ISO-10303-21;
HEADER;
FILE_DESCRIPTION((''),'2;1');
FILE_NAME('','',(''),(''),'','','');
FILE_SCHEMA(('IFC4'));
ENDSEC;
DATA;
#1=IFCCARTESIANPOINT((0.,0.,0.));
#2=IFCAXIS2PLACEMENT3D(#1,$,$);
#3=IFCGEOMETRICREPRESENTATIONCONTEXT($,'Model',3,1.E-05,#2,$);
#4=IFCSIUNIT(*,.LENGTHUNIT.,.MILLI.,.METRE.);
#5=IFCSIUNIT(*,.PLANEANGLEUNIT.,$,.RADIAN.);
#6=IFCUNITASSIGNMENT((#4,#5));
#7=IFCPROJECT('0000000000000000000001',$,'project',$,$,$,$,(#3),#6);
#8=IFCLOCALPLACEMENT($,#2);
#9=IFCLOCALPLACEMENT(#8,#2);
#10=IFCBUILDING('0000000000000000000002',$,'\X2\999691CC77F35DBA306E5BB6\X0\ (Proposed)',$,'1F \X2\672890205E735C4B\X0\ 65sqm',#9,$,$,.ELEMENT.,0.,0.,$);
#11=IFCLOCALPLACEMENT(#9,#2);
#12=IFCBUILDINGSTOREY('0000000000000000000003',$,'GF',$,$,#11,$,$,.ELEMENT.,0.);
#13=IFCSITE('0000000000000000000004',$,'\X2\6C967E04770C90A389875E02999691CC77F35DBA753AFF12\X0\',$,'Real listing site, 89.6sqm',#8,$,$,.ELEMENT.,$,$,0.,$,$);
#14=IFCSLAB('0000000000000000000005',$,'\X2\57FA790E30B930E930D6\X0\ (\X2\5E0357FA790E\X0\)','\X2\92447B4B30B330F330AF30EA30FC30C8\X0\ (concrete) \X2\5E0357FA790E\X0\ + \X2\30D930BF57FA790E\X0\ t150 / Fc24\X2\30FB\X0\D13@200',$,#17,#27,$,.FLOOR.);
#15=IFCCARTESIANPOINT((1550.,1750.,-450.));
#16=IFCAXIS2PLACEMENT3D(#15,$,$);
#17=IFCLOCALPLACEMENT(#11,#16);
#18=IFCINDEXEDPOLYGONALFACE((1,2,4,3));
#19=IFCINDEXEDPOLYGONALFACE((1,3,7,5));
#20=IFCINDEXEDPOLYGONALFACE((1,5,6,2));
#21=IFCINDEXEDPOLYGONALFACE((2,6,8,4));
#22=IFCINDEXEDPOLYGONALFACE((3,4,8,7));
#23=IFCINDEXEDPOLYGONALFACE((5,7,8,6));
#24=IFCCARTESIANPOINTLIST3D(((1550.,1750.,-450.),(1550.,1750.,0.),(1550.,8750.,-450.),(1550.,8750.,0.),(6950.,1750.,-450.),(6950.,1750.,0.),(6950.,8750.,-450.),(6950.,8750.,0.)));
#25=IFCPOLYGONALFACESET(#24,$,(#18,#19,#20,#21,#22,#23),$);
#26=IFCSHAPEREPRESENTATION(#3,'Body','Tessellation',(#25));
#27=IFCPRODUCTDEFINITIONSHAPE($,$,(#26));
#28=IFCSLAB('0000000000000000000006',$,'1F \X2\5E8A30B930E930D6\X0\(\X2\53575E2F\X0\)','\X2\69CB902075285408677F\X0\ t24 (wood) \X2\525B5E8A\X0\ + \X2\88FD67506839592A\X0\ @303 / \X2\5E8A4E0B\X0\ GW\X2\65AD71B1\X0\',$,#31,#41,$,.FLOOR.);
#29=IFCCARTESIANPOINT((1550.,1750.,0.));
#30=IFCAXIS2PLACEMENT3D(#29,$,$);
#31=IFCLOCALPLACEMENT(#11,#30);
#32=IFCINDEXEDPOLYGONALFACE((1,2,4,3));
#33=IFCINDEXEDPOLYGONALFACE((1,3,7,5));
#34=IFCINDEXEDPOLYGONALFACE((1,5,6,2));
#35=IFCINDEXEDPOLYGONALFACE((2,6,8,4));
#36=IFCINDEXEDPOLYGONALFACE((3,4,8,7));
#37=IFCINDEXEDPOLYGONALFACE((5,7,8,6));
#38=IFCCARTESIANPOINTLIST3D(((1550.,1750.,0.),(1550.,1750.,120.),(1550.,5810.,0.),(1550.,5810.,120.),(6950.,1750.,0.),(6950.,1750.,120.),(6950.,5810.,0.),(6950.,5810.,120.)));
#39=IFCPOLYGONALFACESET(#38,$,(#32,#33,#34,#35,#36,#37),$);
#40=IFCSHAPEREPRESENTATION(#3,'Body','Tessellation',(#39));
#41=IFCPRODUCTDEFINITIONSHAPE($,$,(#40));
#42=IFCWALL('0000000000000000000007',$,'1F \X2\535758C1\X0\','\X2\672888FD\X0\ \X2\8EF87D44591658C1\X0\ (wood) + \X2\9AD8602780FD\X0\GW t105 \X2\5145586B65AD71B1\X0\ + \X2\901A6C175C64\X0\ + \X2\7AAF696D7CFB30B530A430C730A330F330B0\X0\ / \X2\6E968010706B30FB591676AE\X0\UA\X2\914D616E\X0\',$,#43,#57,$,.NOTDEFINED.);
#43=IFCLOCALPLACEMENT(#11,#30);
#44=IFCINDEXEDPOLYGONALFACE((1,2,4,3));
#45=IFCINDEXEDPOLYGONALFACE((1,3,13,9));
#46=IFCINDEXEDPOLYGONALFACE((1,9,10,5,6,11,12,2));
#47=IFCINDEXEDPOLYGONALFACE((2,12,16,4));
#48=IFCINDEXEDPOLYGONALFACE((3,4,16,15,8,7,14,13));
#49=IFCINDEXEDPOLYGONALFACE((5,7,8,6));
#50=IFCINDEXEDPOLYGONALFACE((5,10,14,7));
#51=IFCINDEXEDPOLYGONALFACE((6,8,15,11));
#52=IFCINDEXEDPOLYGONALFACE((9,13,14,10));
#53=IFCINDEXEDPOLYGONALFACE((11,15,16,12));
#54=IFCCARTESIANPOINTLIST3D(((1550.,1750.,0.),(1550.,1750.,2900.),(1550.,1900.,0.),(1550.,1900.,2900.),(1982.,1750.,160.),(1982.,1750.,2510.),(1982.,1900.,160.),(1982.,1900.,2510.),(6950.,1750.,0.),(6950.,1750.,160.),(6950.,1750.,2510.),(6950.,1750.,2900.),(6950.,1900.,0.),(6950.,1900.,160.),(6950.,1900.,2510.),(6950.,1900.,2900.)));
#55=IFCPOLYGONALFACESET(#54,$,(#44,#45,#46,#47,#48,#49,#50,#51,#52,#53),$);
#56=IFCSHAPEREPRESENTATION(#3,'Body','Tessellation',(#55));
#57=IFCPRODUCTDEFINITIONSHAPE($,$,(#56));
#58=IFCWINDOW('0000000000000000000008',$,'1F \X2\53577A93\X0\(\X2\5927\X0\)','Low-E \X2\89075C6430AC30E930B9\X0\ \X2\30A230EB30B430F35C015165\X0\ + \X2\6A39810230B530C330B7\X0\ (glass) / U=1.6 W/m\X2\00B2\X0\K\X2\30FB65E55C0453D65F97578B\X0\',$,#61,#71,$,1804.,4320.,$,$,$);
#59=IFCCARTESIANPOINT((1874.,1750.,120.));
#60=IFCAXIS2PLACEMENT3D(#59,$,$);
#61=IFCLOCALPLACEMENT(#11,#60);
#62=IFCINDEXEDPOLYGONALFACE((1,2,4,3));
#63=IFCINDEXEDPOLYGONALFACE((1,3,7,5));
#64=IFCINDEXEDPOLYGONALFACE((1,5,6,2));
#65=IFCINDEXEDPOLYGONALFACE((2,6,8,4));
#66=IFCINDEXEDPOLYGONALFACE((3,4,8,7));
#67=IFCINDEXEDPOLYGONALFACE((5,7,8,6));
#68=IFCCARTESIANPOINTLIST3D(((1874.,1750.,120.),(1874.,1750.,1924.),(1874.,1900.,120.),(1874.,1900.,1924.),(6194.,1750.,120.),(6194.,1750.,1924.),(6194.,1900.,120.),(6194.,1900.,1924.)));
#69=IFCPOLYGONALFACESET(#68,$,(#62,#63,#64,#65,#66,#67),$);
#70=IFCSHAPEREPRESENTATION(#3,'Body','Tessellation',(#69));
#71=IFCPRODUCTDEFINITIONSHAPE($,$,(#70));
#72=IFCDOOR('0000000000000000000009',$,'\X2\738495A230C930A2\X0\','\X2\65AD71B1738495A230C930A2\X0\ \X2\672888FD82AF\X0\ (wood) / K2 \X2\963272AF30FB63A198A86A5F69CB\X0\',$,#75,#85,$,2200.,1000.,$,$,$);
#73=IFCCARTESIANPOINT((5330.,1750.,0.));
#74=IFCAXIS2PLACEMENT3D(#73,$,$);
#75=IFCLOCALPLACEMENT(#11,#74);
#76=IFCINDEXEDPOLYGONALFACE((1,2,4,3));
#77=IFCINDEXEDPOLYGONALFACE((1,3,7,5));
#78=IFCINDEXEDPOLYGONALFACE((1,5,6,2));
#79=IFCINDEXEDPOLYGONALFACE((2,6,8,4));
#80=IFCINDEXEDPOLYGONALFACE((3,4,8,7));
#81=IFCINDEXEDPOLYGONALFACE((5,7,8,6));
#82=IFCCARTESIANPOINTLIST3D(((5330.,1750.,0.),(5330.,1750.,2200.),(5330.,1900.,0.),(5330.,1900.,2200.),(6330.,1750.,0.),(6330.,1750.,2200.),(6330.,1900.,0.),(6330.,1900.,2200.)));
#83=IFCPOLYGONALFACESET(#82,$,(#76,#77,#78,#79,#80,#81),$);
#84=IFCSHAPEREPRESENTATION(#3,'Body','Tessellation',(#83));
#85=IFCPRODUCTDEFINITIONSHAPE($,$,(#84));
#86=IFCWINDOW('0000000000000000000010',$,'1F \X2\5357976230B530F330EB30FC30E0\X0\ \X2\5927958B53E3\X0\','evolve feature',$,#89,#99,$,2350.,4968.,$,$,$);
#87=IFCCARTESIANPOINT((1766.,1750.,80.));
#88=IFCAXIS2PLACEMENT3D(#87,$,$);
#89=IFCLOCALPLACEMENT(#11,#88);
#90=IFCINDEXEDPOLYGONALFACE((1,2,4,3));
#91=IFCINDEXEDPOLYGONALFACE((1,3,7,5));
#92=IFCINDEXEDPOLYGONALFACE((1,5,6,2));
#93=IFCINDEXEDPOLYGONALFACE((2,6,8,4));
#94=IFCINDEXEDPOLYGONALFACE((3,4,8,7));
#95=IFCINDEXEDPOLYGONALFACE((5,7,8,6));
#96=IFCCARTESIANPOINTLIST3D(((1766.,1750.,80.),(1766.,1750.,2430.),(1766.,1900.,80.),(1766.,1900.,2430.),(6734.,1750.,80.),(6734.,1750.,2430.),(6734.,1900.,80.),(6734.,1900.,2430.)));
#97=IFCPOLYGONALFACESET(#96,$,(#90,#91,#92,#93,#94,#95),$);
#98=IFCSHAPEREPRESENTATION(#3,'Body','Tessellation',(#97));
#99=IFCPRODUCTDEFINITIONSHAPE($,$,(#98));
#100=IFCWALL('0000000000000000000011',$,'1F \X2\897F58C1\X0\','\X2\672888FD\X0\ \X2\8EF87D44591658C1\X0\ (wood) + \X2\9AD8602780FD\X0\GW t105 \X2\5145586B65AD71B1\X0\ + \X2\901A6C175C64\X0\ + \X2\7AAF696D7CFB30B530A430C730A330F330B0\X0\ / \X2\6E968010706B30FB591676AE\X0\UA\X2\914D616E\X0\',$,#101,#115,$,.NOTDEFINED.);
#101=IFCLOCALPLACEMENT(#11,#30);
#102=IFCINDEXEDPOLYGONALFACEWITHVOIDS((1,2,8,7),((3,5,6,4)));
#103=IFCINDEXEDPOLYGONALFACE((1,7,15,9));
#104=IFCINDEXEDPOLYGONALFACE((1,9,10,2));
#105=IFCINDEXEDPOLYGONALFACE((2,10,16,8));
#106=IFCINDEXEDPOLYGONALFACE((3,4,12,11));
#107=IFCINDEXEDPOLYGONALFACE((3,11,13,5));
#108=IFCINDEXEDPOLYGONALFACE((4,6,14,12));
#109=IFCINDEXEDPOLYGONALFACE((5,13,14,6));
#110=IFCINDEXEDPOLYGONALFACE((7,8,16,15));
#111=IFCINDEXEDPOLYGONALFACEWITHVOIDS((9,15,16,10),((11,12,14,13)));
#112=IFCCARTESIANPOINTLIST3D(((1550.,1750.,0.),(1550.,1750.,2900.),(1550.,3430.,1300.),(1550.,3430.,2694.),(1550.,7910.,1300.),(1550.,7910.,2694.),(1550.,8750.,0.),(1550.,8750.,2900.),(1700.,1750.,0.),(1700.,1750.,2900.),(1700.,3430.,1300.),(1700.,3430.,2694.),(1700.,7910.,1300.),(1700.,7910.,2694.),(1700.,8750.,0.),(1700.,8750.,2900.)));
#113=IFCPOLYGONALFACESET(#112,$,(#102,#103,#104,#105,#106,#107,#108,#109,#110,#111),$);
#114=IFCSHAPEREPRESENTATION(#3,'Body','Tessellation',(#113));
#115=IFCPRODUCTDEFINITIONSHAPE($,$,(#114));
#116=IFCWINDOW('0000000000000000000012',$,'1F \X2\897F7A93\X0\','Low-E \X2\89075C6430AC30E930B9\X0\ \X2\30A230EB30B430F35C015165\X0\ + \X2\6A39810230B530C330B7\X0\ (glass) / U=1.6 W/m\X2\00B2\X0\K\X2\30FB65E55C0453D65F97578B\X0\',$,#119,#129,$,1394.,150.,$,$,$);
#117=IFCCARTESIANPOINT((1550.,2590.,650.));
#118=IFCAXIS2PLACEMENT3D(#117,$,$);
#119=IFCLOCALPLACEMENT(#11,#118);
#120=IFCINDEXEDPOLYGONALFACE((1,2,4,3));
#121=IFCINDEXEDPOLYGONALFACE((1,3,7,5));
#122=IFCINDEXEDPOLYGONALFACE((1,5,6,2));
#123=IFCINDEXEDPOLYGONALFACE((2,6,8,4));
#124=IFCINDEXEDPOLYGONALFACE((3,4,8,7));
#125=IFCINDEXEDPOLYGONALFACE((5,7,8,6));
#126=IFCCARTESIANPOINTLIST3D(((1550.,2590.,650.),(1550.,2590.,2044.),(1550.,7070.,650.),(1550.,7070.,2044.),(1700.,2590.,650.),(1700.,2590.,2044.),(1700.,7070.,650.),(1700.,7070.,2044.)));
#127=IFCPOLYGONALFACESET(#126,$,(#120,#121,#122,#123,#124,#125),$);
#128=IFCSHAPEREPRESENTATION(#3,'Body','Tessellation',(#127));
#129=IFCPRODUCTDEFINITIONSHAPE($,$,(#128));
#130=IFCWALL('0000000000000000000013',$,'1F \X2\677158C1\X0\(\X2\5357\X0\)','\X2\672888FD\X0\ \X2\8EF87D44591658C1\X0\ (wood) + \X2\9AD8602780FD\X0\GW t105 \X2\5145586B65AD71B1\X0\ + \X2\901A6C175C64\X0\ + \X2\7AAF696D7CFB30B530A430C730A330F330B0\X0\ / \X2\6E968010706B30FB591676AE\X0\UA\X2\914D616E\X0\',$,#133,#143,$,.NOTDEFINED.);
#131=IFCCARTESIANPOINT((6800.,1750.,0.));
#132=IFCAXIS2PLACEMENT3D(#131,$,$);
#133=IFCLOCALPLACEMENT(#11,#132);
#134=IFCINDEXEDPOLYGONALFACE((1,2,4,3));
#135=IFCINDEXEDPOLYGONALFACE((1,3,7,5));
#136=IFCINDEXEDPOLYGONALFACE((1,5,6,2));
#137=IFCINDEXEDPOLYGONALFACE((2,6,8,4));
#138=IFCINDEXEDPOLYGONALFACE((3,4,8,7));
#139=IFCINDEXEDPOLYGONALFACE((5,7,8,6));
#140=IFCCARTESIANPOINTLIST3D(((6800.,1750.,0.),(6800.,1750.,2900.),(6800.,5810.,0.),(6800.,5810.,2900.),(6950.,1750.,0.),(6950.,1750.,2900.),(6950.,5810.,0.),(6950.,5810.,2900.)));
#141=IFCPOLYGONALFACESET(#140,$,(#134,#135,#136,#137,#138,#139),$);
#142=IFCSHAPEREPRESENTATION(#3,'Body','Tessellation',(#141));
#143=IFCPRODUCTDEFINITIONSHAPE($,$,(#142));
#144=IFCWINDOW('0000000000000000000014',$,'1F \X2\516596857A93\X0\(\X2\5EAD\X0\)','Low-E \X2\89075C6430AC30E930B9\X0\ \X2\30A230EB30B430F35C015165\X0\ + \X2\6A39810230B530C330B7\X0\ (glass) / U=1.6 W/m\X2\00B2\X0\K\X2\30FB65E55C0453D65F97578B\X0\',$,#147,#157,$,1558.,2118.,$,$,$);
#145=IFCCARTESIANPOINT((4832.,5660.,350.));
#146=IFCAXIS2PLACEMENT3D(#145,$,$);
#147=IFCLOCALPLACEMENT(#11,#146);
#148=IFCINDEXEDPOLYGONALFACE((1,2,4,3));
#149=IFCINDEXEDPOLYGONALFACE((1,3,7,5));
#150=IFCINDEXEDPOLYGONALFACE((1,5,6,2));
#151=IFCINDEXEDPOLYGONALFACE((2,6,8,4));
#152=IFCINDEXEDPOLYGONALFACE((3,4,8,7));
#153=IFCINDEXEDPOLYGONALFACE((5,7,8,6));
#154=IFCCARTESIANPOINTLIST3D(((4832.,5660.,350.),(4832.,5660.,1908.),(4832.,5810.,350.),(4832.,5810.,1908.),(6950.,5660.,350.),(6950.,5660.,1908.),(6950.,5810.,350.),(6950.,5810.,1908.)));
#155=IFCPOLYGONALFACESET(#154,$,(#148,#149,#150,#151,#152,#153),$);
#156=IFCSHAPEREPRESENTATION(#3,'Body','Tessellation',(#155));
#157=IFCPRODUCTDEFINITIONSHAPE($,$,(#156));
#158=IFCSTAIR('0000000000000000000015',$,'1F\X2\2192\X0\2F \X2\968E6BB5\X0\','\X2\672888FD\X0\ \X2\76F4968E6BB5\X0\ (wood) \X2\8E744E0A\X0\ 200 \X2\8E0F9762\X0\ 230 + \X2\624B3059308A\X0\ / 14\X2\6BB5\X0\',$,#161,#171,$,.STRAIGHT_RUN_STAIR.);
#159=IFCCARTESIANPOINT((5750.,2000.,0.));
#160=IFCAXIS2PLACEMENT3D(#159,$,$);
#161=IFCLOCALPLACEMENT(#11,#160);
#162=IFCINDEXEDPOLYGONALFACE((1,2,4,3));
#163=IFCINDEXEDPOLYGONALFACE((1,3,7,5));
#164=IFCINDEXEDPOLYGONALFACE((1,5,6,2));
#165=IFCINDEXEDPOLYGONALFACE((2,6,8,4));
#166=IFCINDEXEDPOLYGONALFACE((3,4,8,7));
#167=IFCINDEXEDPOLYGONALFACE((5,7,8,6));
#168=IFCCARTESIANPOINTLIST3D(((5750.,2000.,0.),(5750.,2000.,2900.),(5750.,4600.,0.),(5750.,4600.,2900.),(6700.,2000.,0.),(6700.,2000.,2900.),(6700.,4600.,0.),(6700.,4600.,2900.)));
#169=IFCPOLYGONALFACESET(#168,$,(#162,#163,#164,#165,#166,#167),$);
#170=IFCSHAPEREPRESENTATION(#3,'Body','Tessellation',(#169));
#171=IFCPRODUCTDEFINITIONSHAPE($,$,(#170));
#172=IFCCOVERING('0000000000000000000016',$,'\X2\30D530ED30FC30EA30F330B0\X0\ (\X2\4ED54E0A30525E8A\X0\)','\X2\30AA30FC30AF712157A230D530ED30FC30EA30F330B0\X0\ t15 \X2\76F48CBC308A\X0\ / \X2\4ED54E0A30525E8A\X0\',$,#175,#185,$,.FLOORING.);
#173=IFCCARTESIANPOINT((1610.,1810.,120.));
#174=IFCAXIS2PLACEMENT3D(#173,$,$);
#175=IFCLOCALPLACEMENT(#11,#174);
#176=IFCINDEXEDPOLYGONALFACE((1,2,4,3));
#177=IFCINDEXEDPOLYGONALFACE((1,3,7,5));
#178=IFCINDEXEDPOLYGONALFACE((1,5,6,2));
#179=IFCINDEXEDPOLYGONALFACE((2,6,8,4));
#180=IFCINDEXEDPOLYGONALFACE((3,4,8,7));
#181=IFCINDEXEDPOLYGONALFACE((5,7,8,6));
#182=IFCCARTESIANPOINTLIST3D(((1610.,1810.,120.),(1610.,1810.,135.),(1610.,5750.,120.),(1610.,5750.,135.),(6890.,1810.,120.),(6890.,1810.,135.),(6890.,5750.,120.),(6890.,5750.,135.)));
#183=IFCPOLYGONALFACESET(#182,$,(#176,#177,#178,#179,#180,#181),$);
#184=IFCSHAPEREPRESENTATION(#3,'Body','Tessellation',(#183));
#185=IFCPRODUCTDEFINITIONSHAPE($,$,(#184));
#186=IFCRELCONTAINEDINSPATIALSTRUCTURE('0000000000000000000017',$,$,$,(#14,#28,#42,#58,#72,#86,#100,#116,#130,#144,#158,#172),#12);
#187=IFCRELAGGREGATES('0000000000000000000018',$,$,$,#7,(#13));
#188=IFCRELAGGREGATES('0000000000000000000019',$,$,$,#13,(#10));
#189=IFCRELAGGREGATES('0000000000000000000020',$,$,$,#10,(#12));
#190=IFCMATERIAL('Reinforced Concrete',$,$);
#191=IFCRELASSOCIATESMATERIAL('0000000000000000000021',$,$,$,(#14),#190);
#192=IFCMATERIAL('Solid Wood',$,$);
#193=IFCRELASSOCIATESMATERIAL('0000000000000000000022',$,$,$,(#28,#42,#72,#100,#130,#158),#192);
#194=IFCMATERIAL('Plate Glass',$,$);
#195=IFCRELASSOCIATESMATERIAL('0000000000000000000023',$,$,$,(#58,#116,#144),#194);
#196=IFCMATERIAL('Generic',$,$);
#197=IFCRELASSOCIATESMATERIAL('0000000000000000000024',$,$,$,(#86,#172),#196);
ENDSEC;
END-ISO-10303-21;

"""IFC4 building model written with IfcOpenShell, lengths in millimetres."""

from ifc_helpers import new_model, si_unit, frame, frame_2d, origin, place, context, project, spatial, rectangle, extrude, material, element, fill, save


model = new_model("IFC4")

# Units and contexts
model_context = context("Model", 3, precision=1e-05, world=origin())
ifc_project = project(units=[si_unit("LENGTHUNIT", "METRE", prefix="MILLI"), si_unit("PLANEANGLEUNIT", "RADIAN")], contexts=[model_context])

# Site, building, storey
site_placement = place(None, origin())
site = spatial("IfcSite", under=ifc_project, at=site_placement, Name="沖縄県那覇市首里石嶺町２", ObjectType="Real listing site, 89.6sqm", CompositionType="ELEMENT", RefElevation=0.0)
building_placement = place(site_placement, origin())
building = spatial("IfcBuilding", under=site, at=building_placement, Name="首里石嶺の家 (Proposed)", ObjectType="1F 木造平屋 65sqm", CompositionType="ELEMENT", ElevationOfRefHeight=0.0, ElevationOfTerrain=0.0)
storey_placement = place(building_placement, origin())
storey = spatial("IfcBuildingStorey", under=building, at=storey_placement, Name="GF", CompositionType="ELEMENT", Elevation=0.0)

# Slabs
ifc_material_1 = material(Name="Reinforced Concrete")
slab_1_placement = place(storey_placement, frame((1550.0, 1750.0, -450.0)))
element("IfcSlab", 1, at=slab_1_placement, inside=storey, material=ifc_material_1, Name="基礎スラブ (布基礎)", Description="鉄筋コンクリート (concrete) 布基礎 + ベタ基礎 t150 / Fc24・D13@200", PredefinedType="FLOOR", context=model_context, shape_type="SweptSolid", body=[
    extrude(rectangle(XDim=5400.0, YDim=7000.0, at=frame_2d((2700.0, 3500.0))), frame((1550.0, 1750.0, -450.0)), (0.0, 0.0, 1.0), 450.0),
])
ifc_material_2 = material(Name="Solid Wood")
slab_2_placement = place(storey_placement, frame((1550.0, 1750.0, 0.0)))
element("IfcSlab", 2, at=slab_2_placement, inside=storey, material=ifc_material_2, Name="1F 床スラブ(南帯)", Description="構造用合板 t24 (wood) 剛床 + 製材根太 @303 / 床下 GW断熱", PredefinedType="FLOOR", context=model_context, shape_type="SweptSolid", body=[
    extrude(rectangle(XDim=5400.0, YDim=4060.0, at=frame_2d((2700.0, 2030.0))), frame((1550.0, 1750.0, 0.0)), (0.0, 0.0, 1.0), 120.0),
])

# Wall, openings, windows, door
wall_1_placement = place(storey_placement, frame((1550.0, 1750.0, 0.0)))
wall_1 = element("IfcWall", 3, at=wall_1_placement, inside=storey, material=ifc_material_2, Name="1F 南壁", Description="木製 軸組外壁 (wood) + 高性能GW t105 充填断熱 + 通気層 + 窯業系サイディング / 準耐火・外皮UA配慮", PredefinedType="NOTDEFINED", context=model_context, shape_type="SweptSolid", body=[
    extrude(rectangle(XDim=5400.0, YDim=150.0, at=frame_2d((2700.0, 75.0))), frame((1550.0, 1750.0, 0.0)), (0.0, 0.0, 1.0), 2900.0),
])
opening_1_placement = place(storey_placement, frame((1874.0, 1750.0, 120.0)))
opening_1 = element("IfcOpeningElement", 4, at=opening_1_placement, cuts=wall_1, PredefinedType="NOTDEFINED", context=model_context, shape_type="SweptSolid", body=[
    extrude(rectangle(XDim=4320.0, YDim=150.0, at=frame_2d((2160.0, 75.0))), frame((1874.0, 1750.0, 120.0)), (0.0, 0.0, 1.0), 1804.0),
])
opening_2_placement = place(storey_placement, frame((5330.0, 1750.0, 0.0)))
opening_2 = element("IfcOpeningElement", 5, at=opening_2_placement, cuts=wall_1, PredefinedType="NOTDEFINED", context=model_context, shape_type="SweptSolid", body=[
    extrude(rectangle(XDim=1000.0, YDim=150.0, at=frame_2d((500.0, 75.0))), frame((5330.0, 1750.0, 0.0)), (0.0, 0.0, 1.0), 2200.0),
])
opening_3_placement = place(storey_placement, frame((1766.0, 1750.0, 80.0)))
opening_3 = element("IfcOpeningElement", 6, at=opening_3_placement, cuts=wall_1, PredefinedType="NOTDEFINED", context=model_context, shape_type="SweptSolid", body=[
    extrude(rectangle(XDim=4968.0, YDim=150.0, at=frame_2d((2484.0, 75.0))), frame((1766.0, 1750.0, 80.0)), (0.0, 0.0, 1.0), 2350.0),
])
ifc_material_3 = material(Name="Plate Glass")
window_1_placement = place(storey_placement, frame((1874.0, 1750.0, 120.0)))
window_1 = element("IfcWindow", 7, at=window_1_placement, inside=storey, material=ifc_material_3, Name="1F 南窓(大)", Description="Low-E 複層ガラス アルゴン封入 + 樹脂サッシ (glass) / U=1.6 W/m²K・日射取得型", OverallHeight=1804.0, OverallWidth=4320.0, context=model_context, shape_type="SweptSolid", body=[
    extrude(rectangle(XDim=4320.0, YDim=150.0, at=frame_2d((2160.0, 75.0))), frame((1874.0, 1750.0, 120.0)), (0.0, 0.0, 1.0), 1804.0),
])
fill(opening_1, window_1)
door_1_placement = place(storey_placement, frame((5330.0, 1750.0, 0.0)))
door_1 = element("IfcDoor", 8, at=door_1_placement, inside=storey, material=ifc_material_2, Name="玄関ドア", Description="断熱玄関ドア 木製芯 (wood) / K2 防犯・採風機構", OverallHeight=2200.0, OverallWidth=1000.0, context=model_context, shape_type="SweptSolid", body=[
    extrude(rectangle(XDim=1000.0, YDim=150.0, at=frame_2d((500.0, 75.0))), frame((5330.0, 1750.0, 0.0)), (0.0, 0.0, 1.0), 2200.0),
])
fill(opening_2, door_1)
ifc_material_4 = material(Name="Generic")
window_2_placement = place(storey_placement, frame((1766.0, 1750.0, 80.0)))
window_2 = element("IfcWindow", 9, at=window_2_placement, inside=storey, material=ifc_material_4, Name="1F 南面サンルーム 大開口", Description="evolve feature", OverallHeight=2350.0, OverallWidth=4968.0, context=model_context, shape_type="SweptSolid", body=[
    extrude(rectangle(XDim=4968.0, YDim=150.0, at=frame_2d((2484.0, 75.0))), frame((1766.0, 1750.0, 80.0)), (0.0, 0.0, 1.0), 2350.0),
])
fill(opening_3, window_2)

# Walls, openings, windows
wall_2_placement = place(storey_placement, frame((1550.0, 1750.0, 0.0)))
wall_2 = element("IfcWall", 10, at=wall_2_placement, inside=storey, material=ifc_material_2, Name="1F 西壁", Description="木製 軸組外壁 (wood) + 高性能GW t105 充填断熱 + 通気層 + 窯業系サイディング / 準耐火・外皮UA配慮", PredefinedType="NOTDEFINED", context=model_context, shape_type="SweptSolid", body=[
    extrude(rectangle(XDim=150.0, YDim=7000.0, at=frame_2d((75.0, 3500.0))), frame((1550.0, 1750.0, 0.0)), (0.0, 0.0, 1.0), 2900.0),
])
opening_4_placement = place(storey_placement, frame((1550.0, 2590.0, 650.0)))
opening_4 = element("IfcOpeningElement", 11, at=opening_4_placement, cuts=wall_2, PredefinedType="NOTDEFINED", context=model_context, shape_type="SweptSolid", body=[
    extrude(rectangle(XDim=150.0, YDim=4480.0, at=frame_2d((75.0, 2240.0))), frame((1550.0, 2590.0, 650.0)), (0.0, 0.0, 1.0), 1394.0),
])
window_3_placement = place(storey_placement, frame((1550.0, 2590.0, 650.0)))
window_3 = element("IfcWindow", 12, at=window_3_placement, inside=storey, material=ifc_material_3, Name="1F 西窓", Description="Low-E 複層ガラス アルゴン封入 + 樹脂サッシ (glass) / U=1.6 W/m²K・日射取得型", OverallHeight=1394.0, OverallWidth=150.0, context=model_context, shape_type="SweptSolid", body=[
    extrude(rectangle(XDim=150.0, YDim=4480.0, at=frame_2d((75.0, 2240.0))), frame((1550.0, 2590.0, 650.0)), (0.0, 0.0, 1.0), 1394.0),
])
fill(opening_4, window_3)
wall_3_placement = place(storey_placement, frame((6800.0, 1750.0, 0.0)))
wall_3 = element("IfcWall", 13, at=wall_3_placement, inside=storey, material=ifc_material_2, Name="1F 東壁(南)", Description="木製 軸組外壁 (wood) + 高性能GW t105 充填断熱 + 通気層 + 窯業系サイディング / 準耐火・外皮UA配慮", PredefinedType="NOTDEFINED", context=model_context, shape_type="SweptSolid", body=[
    extrude(rectangle(XDim=150.0, YDim=4060.0, at=frame_2d((75.0, 2030.0))), frame((6800.0, 1750.0, 0.0)), (0.0, 0.0, 1.0), 2900.0),
])
opening_5_placement = place(storey_placement, frame((4832.0, 5660.0, 350.0)))
opening_5 = element("IfcOpeningElement", 14, at=opening_5_placement, cuts=wall_3, PredefinedType="NOTDEFINED", context=model_context, shape_type="SweptSolid", body=[
    extrude(rectangle(XDim=2118.0, YDim=150.0, at=frame_2d((1059.0, 75.0))), frame((4832.0, 5660.0, 350.0)), (0.0, 0.0, 1.0), 1558.0),
])
window_4_placement = place(storey_placement, frame((4832.0, 5660.0, 350.0)))
window_4 = element("IfcWindow", 15, at=window_4_placement, inside=storey, material=ifc_material_3, Name="1F 入隅窓(庭)", Description="Low-E 複層ガラス アルゴン封入 + 樹脂サッシ (glass) / U=1.6 W/m²K・日射取得型", OverallHeight=1558.0, OverallWidth=2118.0, context=model_context, shape_type="SweptSolid", body=[
    extrude(rectangle(XDim=2118.0, YDim=150.0, at=frame_2d((1059.0, 75.0))), frame((4832.0, 5660.0, 350.0)), (0.0, 0.0, 1.0), 1558.0),
])
fill(opening_5, window_4)

# Stair
stair_placement = place(storey_placement, frame((5750.0, 2000.0, 0.0)))
element("IfcStair", 16, at=stair_placement, inside=storey, material=ifc_material_2, Name="1F→2F 階段", Description="木製 直階段 (wood) 蹴上 200 踏面 230 + 手すり / 14段", PredefinedType="STRAIGHT_RUN_STAIR", context=model_context, shape_type="SweptSolid", body=[
    extrude(rectangle(XDim=950.0, YDim=2600.0, at=frame_2d((475.0, 1300.0))), frame((5750.0, 2000.0, 0.0)), (0.0, 0.0, 1.0), 2900.0),
])

# Covering
covering_placement = place(storey_placement, frame((1610.0, 1810.0, 120.0)))
element("IfcCovering", 17, at=covering_placement, inside=storey, material=ifc_material_4, Name="フローリング (仕上げ床)", Description="オーク無垢フローリング t15 直貼り / 仕上げ床", PredefinedType="FLOORING", context=model_context, shape_type="SweptSolid", body=[
    extrude(rectangle(XDim=5280.0, YDim=3940.0, at=frame_2d((2640.0, 1970.0))), frame((1610.0, 1810.0, 120.0)), (0.0, 0.0, 1.0), 15.0),
])

save(model, "model.ifc")
